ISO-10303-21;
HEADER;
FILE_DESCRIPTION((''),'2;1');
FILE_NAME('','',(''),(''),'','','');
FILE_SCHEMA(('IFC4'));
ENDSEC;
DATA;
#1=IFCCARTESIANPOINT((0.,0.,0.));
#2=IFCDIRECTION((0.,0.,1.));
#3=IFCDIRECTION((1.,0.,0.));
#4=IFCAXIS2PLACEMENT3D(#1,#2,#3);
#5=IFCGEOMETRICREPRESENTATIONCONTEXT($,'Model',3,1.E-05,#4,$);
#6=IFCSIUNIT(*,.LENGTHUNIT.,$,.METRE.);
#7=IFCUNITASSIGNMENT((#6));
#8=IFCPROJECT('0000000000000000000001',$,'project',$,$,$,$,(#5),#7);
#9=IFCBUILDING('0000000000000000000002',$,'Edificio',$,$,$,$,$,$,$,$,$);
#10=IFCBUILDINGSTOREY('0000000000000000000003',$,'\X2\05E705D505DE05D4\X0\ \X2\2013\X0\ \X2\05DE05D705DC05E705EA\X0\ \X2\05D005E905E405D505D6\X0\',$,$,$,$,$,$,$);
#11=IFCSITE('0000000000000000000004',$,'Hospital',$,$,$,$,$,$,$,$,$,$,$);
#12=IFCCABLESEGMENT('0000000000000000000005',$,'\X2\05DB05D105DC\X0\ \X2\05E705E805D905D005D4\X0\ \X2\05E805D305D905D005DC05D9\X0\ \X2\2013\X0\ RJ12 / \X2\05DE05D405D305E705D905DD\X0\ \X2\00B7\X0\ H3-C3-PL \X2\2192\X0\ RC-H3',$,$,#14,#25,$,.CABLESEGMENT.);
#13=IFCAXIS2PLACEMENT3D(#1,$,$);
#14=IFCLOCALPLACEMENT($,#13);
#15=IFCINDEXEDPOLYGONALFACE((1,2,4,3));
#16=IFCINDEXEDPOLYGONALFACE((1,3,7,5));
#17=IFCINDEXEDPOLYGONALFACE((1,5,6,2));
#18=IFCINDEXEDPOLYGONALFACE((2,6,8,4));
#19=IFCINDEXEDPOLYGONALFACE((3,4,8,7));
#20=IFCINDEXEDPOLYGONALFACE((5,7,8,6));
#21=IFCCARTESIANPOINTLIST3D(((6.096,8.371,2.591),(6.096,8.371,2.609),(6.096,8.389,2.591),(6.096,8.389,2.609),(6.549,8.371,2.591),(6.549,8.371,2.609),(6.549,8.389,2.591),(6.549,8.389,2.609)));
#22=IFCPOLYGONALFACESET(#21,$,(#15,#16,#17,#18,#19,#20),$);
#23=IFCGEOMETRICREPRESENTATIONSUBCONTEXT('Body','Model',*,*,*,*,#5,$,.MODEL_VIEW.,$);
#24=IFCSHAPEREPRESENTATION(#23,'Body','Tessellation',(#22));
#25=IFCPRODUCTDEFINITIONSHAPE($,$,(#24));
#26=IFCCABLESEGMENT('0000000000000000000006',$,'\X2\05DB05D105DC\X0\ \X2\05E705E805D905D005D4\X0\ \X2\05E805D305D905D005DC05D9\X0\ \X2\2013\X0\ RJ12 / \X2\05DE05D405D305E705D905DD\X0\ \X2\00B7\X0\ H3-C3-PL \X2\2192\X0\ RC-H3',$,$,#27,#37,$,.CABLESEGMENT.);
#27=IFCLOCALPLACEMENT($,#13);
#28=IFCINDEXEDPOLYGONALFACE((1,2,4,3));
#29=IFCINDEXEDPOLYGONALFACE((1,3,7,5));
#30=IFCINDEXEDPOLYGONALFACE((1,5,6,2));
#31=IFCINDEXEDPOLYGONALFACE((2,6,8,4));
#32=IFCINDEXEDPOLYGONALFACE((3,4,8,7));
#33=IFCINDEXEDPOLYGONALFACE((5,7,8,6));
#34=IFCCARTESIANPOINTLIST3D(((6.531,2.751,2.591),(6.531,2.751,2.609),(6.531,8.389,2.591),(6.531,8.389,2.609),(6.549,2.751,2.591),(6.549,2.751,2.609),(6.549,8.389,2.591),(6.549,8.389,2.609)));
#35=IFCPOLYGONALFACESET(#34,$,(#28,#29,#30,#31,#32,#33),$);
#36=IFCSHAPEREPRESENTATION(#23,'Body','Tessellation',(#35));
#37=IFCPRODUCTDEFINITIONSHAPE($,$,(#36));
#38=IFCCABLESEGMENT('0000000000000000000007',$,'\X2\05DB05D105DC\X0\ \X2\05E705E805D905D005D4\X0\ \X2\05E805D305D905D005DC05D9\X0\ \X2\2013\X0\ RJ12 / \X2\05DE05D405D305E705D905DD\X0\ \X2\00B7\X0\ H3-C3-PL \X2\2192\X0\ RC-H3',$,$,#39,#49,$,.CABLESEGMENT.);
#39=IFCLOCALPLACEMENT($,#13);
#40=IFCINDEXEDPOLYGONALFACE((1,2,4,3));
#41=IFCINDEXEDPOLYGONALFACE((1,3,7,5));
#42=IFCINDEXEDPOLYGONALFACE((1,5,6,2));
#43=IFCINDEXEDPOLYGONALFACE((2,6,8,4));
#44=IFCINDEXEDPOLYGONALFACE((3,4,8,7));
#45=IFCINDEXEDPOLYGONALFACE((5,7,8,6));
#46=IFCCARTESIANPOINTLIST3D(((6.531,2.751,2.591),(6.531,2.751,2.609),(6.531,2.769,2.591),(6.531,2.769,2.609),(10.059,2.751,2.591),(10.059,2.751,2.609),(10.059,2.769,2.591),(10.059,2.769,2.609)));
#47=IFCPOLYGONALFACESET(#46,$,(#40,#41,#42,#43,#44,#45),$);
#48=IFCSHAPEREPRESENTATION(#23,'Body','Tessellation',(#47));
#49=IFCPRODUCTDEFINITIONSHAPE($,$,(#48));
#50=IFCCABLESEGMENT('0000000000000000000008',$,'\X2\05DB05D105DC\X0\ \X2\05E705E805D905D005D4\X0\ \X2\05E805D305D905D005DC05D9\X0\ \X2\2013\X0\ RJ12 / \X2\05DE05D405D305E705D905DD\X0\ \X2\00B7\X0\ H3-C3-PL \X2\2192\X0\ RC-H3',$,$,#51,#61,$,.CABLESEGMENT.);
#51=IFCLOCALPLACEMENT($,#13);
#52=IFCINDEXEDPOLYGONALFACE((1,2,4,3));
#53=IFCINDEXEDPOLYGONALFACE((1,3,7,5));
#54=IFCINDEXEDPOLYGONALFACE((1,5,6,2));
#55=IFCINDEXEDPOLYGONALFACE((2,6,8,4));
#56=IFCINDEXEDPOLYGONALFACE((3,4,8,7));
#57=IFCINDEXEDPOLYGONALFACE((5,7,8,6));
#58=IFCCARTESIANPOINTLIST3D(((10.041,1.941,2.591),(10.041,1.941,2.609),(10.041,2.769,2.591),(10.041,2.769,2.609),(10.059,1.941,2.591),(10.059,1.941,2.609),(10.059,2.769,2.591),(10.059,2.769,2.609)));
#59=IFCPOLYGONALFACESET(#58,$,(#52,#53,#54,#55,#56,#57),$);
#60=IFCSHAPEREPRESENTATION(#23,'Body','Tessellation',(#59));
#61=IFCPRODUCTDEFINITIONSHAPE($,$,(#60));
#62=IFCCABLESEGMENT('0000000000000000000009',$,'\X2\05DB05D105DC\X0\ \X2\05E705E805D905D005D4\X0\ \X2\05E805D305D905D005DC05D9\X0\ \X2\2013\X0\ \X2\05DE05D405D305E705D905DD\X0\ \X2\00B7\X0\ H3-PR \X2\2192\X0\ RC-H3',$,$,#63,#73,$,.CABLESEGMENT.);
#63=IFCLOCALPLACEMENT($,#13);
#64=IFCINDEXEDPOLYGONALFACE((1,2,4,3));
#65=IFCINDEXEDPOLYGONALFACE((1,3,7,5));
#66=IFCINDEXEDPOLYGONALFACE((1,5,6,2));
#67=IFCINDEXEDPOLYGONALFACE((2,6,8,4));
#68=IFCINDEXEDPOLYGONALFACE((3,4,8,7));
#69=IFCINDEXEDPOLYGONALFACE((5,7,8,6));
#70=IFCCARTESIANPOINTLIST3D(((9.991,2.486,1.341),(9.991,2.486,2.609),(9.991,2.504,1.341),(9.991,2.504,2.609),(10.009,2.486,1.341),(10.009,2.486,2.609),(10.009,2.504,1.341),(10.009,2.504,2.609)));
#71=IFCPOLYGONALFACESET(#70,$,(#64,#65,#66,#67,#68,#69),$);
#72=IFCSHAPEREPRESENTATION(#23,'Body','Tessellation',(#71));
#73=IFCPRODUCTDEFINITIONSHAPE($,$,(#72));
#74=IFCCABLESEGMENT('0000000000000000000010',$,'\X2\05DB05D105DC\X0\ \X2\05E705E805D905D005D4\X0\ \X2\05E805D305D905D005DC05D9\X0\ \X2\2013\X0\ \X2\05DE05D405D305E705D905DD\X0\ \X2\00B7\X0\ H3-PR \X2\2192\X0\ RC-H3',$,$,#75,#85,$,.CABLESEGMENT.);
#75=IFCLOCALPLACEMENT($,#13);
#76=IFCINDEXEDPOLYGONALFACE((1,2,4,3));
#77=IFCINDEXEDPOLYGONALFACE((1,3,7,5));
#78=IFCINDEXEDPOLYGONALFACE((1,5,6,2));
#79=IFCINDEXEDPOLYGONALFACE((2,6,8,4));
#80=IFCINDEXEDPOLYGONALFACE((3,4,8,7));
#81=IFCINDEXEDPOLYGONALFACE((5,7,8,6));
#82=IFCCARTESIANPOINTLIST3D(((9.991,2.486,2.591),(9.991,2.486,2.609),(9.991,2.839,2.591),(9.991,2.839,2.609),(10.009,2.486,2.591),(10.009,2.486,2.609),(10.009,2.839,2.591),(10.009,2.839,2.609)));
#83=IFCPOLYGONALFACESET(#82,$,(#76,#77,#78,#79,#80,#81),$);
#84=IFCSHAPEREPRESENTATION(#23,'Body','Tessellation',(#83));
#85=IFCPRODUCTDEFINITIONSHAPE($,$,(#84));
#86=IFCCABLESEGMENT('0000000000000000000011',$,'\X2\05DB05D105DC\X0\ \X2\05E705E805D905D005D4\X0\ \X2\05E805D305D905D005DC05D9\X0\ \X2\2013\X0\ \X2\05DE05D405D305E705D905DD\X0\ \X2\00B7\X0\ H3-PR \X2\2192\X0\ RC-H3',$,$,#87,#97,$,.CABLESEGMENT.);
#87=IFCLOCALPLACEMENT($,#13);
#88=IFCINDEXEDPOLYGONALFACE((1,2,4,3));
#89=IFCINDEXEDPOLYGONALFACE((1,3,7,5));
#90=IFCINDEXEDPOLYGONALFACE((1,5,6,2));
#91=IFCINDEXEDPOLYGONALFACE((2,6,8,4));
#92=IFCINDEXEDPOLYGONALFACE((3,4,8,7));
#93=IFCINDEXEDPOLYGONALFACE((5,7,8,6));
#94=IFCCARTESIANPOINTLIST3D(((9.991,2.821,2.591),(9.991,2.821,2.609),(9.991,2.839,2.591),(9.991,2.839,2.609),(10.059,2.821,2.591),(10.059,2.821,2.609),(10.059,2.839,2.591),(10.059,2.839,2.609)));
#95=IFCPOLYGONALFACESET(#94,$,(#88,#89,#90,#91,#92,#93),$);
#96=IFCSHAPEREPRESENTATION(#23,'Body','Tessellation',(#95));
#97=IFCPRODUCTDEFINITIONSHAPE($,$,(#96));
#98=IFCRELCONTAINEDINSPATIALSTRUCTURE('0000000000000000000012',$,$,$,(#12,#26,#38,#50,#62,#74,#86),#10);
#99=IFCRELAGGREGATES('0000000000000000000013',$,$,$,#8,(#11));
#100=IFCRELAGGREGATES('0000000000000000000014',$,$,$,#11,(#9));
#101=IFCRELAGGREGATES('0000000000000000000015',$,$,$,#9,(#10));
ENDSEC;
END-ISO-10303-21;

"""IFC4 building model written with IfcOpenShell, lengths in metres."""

from ifc_helpers import new_model, si_unit, frame, origin_with_axes, context, subcontext, project, spatial, line, indexed_curve, outline, extrude, element, save


model = new_model("IFC4")

# Units and contexts
model_context = context("Model", 3, precision=1e-05, world=origin_with_axes())
body_context = subcontext(model_context, "Body", "Model", "MODEL_VIEW")
ifc_project = project(units=[si_unit("LENGTHUNIT", "METRE")], contexts=[model_context])

# Site, building, storey
site = spatial("IfcSite", under=ifc_project, Name="Hospital")
building = spatial("IfcBuilding", under=site, Name="Edificio")
storey = spatial("IfcBuildingStorey", under=building, Name="קומה – מחלקת אשפוז")

# Cable segments
element("IfcCableSegment", 1, inside=storey, Name="כבל קריאה רדיאלי – RJ12 / מהדקים · H3-C3-PL → RC-H3", PredefinedType="CABLESEGMENT", context=body_context, shape_type="SweptSolid", body=[
    extrude(outline(indexed_curve([(0.0, 0.0), (0.453, 0.0), (0.453, 0.018), (0.0, 0.018)], segments=[line(1, 2, 3, 4, 1)])), frame((6.096, 8.371, 2.591), z_axis=(0.0, 0.0, 1.0), x_axis=(1.0, 0.0, 0.0)), (0.0, 0.0, 1.0), 0.018),
])
element("IfcCableSegment", 2, inside=storey, Name="כבל קריאה רדיאלי – RJ12 / מהדקים · H3-C3-PL → RC-H3", PredefinedType="CABLESEGMENT", context=body_context, shape_type="SweptSolid", body=[
    extrude(outline(indexed_curve([(0.0, 0.0), (0.018, 0.0), (0.018, 5.638), (0.0, 5.638)], segments=[line(1, 2, 3, 4, 1)])), frame((6.531, 2.751, 2.591), z_axis=(0.0, 0.0, 1.0), x_axis=(1.0, 0.0, 0.0)), (0.0, 0.0, 1.0), 0.018),
])
element("IfcCableSegment", 3, inside=storey, Name="כבל קריאה רדיאלי – RJ12 / מהדקים · H3-C3-PL → RC-H3", PredefinedType="CABLESEGMENT", context=body_context, shape_type="SweptSolid", body=[
    extrude(outline(indexed_curve([(0.0, 0.0), (3.528, 0.0), (3.528, 0.018), (0.0, 0.018)], segments=[line(1, 2, 3, 4, 1)])), frame((6.531, 2.751, 2.591), z_axis=(0.0, 0.0, 1.0), x_axis=(1.0, 0.0, 0.0)), (0.0, 0.0, 1.0), 0.018),
])
element("IfcCableSegment", 4, inside=storey, Name="כבל קריאה רדיאלי – RJ12 / מהדקים · H3-C3-PL → RC-H3", PredefinedType="CABLESEGMENT", context=body_context, shape_type="SweptSolid", body=[
    extrude(outline(indexed_curve([(0.0, 0.0), (0.018, 0.0), (0.018, 0.828), (0.0, 0.828)], segments=[line(1, 2, 3, 4, 1)])), frame((10.041, 1.941, 2.591), z_axis=(0.0, 0.0, 1.0), x_axis=(1.0, 0.0, 0.0)), (0.0, 0.0, 1.0), 0.018),
])
element("IfcCableSegment", 5, inside=storey, Name="כבל קריאה רדיאלי – מהדקים · H3-PR → RC-H3", PredefinedType="CABLESEGMENT", context=body_context, shape_type="SweptSolid", body=[
    extrude(outline(indexed_curve([(0.0, 0.0), (0.018, 0.0), (0.018, 0.018), (0.0, 0.018)], segments=[line(1, 2, 3, 4, 1)])), frame((9.991, 2.486, 1.341), z_axis=(0.0, 0.0, 1.0), x_axis=(1.0, 0.0, 0.0)), (0.0, 0.0, 1.0), 1.268),
])
element("IfcCableSegment", 6, inside=storey, Name="כבל קריאה רדיאלי – מהדקים · H3-PR → RC-H3", PredefinedType="CABLESEGMENT", context=body_context, shape_type="SweptSolid", body=[
    extrude(outline(indexed_curve([(0.0, 0.0), (0.018, 0.0), (0.018, 0.353), (0.0, 0.353)], segments=[line(1, 2, 3, 4, 1)])), frame((9.991, 2.486, 2.591), z_axis=(0.0, 0.0, 1.0), x_axis=(1.0, 0.0, 0.0)), (0.0, 0.0, 1.0), 0.018),
])
element("IfcCableSegment", 7, inside=storey, Name="כבל קריאה רדיאלי – מהדקים · H3-PR → RC-H3", PredefinedType="CABLESEGMENT", context=body_context, shape_type="SweptSolid", body=[
    extrude(outline(indexed_curve([(0.0, 0.0), (0.068, 0.0), (0.068, 0.018), (0.0, 0.018)], segments=[line(1, 2, 3, 4, 1)])), frame((9.991, 2.821, 2.591), z_axis=(0.0, 0.0, 1.0), x_axis=(1.0, 0.0, 0.0)), (0.0, 0.0, 1.0), 0.018),
])

save(model, "model.ifc")
